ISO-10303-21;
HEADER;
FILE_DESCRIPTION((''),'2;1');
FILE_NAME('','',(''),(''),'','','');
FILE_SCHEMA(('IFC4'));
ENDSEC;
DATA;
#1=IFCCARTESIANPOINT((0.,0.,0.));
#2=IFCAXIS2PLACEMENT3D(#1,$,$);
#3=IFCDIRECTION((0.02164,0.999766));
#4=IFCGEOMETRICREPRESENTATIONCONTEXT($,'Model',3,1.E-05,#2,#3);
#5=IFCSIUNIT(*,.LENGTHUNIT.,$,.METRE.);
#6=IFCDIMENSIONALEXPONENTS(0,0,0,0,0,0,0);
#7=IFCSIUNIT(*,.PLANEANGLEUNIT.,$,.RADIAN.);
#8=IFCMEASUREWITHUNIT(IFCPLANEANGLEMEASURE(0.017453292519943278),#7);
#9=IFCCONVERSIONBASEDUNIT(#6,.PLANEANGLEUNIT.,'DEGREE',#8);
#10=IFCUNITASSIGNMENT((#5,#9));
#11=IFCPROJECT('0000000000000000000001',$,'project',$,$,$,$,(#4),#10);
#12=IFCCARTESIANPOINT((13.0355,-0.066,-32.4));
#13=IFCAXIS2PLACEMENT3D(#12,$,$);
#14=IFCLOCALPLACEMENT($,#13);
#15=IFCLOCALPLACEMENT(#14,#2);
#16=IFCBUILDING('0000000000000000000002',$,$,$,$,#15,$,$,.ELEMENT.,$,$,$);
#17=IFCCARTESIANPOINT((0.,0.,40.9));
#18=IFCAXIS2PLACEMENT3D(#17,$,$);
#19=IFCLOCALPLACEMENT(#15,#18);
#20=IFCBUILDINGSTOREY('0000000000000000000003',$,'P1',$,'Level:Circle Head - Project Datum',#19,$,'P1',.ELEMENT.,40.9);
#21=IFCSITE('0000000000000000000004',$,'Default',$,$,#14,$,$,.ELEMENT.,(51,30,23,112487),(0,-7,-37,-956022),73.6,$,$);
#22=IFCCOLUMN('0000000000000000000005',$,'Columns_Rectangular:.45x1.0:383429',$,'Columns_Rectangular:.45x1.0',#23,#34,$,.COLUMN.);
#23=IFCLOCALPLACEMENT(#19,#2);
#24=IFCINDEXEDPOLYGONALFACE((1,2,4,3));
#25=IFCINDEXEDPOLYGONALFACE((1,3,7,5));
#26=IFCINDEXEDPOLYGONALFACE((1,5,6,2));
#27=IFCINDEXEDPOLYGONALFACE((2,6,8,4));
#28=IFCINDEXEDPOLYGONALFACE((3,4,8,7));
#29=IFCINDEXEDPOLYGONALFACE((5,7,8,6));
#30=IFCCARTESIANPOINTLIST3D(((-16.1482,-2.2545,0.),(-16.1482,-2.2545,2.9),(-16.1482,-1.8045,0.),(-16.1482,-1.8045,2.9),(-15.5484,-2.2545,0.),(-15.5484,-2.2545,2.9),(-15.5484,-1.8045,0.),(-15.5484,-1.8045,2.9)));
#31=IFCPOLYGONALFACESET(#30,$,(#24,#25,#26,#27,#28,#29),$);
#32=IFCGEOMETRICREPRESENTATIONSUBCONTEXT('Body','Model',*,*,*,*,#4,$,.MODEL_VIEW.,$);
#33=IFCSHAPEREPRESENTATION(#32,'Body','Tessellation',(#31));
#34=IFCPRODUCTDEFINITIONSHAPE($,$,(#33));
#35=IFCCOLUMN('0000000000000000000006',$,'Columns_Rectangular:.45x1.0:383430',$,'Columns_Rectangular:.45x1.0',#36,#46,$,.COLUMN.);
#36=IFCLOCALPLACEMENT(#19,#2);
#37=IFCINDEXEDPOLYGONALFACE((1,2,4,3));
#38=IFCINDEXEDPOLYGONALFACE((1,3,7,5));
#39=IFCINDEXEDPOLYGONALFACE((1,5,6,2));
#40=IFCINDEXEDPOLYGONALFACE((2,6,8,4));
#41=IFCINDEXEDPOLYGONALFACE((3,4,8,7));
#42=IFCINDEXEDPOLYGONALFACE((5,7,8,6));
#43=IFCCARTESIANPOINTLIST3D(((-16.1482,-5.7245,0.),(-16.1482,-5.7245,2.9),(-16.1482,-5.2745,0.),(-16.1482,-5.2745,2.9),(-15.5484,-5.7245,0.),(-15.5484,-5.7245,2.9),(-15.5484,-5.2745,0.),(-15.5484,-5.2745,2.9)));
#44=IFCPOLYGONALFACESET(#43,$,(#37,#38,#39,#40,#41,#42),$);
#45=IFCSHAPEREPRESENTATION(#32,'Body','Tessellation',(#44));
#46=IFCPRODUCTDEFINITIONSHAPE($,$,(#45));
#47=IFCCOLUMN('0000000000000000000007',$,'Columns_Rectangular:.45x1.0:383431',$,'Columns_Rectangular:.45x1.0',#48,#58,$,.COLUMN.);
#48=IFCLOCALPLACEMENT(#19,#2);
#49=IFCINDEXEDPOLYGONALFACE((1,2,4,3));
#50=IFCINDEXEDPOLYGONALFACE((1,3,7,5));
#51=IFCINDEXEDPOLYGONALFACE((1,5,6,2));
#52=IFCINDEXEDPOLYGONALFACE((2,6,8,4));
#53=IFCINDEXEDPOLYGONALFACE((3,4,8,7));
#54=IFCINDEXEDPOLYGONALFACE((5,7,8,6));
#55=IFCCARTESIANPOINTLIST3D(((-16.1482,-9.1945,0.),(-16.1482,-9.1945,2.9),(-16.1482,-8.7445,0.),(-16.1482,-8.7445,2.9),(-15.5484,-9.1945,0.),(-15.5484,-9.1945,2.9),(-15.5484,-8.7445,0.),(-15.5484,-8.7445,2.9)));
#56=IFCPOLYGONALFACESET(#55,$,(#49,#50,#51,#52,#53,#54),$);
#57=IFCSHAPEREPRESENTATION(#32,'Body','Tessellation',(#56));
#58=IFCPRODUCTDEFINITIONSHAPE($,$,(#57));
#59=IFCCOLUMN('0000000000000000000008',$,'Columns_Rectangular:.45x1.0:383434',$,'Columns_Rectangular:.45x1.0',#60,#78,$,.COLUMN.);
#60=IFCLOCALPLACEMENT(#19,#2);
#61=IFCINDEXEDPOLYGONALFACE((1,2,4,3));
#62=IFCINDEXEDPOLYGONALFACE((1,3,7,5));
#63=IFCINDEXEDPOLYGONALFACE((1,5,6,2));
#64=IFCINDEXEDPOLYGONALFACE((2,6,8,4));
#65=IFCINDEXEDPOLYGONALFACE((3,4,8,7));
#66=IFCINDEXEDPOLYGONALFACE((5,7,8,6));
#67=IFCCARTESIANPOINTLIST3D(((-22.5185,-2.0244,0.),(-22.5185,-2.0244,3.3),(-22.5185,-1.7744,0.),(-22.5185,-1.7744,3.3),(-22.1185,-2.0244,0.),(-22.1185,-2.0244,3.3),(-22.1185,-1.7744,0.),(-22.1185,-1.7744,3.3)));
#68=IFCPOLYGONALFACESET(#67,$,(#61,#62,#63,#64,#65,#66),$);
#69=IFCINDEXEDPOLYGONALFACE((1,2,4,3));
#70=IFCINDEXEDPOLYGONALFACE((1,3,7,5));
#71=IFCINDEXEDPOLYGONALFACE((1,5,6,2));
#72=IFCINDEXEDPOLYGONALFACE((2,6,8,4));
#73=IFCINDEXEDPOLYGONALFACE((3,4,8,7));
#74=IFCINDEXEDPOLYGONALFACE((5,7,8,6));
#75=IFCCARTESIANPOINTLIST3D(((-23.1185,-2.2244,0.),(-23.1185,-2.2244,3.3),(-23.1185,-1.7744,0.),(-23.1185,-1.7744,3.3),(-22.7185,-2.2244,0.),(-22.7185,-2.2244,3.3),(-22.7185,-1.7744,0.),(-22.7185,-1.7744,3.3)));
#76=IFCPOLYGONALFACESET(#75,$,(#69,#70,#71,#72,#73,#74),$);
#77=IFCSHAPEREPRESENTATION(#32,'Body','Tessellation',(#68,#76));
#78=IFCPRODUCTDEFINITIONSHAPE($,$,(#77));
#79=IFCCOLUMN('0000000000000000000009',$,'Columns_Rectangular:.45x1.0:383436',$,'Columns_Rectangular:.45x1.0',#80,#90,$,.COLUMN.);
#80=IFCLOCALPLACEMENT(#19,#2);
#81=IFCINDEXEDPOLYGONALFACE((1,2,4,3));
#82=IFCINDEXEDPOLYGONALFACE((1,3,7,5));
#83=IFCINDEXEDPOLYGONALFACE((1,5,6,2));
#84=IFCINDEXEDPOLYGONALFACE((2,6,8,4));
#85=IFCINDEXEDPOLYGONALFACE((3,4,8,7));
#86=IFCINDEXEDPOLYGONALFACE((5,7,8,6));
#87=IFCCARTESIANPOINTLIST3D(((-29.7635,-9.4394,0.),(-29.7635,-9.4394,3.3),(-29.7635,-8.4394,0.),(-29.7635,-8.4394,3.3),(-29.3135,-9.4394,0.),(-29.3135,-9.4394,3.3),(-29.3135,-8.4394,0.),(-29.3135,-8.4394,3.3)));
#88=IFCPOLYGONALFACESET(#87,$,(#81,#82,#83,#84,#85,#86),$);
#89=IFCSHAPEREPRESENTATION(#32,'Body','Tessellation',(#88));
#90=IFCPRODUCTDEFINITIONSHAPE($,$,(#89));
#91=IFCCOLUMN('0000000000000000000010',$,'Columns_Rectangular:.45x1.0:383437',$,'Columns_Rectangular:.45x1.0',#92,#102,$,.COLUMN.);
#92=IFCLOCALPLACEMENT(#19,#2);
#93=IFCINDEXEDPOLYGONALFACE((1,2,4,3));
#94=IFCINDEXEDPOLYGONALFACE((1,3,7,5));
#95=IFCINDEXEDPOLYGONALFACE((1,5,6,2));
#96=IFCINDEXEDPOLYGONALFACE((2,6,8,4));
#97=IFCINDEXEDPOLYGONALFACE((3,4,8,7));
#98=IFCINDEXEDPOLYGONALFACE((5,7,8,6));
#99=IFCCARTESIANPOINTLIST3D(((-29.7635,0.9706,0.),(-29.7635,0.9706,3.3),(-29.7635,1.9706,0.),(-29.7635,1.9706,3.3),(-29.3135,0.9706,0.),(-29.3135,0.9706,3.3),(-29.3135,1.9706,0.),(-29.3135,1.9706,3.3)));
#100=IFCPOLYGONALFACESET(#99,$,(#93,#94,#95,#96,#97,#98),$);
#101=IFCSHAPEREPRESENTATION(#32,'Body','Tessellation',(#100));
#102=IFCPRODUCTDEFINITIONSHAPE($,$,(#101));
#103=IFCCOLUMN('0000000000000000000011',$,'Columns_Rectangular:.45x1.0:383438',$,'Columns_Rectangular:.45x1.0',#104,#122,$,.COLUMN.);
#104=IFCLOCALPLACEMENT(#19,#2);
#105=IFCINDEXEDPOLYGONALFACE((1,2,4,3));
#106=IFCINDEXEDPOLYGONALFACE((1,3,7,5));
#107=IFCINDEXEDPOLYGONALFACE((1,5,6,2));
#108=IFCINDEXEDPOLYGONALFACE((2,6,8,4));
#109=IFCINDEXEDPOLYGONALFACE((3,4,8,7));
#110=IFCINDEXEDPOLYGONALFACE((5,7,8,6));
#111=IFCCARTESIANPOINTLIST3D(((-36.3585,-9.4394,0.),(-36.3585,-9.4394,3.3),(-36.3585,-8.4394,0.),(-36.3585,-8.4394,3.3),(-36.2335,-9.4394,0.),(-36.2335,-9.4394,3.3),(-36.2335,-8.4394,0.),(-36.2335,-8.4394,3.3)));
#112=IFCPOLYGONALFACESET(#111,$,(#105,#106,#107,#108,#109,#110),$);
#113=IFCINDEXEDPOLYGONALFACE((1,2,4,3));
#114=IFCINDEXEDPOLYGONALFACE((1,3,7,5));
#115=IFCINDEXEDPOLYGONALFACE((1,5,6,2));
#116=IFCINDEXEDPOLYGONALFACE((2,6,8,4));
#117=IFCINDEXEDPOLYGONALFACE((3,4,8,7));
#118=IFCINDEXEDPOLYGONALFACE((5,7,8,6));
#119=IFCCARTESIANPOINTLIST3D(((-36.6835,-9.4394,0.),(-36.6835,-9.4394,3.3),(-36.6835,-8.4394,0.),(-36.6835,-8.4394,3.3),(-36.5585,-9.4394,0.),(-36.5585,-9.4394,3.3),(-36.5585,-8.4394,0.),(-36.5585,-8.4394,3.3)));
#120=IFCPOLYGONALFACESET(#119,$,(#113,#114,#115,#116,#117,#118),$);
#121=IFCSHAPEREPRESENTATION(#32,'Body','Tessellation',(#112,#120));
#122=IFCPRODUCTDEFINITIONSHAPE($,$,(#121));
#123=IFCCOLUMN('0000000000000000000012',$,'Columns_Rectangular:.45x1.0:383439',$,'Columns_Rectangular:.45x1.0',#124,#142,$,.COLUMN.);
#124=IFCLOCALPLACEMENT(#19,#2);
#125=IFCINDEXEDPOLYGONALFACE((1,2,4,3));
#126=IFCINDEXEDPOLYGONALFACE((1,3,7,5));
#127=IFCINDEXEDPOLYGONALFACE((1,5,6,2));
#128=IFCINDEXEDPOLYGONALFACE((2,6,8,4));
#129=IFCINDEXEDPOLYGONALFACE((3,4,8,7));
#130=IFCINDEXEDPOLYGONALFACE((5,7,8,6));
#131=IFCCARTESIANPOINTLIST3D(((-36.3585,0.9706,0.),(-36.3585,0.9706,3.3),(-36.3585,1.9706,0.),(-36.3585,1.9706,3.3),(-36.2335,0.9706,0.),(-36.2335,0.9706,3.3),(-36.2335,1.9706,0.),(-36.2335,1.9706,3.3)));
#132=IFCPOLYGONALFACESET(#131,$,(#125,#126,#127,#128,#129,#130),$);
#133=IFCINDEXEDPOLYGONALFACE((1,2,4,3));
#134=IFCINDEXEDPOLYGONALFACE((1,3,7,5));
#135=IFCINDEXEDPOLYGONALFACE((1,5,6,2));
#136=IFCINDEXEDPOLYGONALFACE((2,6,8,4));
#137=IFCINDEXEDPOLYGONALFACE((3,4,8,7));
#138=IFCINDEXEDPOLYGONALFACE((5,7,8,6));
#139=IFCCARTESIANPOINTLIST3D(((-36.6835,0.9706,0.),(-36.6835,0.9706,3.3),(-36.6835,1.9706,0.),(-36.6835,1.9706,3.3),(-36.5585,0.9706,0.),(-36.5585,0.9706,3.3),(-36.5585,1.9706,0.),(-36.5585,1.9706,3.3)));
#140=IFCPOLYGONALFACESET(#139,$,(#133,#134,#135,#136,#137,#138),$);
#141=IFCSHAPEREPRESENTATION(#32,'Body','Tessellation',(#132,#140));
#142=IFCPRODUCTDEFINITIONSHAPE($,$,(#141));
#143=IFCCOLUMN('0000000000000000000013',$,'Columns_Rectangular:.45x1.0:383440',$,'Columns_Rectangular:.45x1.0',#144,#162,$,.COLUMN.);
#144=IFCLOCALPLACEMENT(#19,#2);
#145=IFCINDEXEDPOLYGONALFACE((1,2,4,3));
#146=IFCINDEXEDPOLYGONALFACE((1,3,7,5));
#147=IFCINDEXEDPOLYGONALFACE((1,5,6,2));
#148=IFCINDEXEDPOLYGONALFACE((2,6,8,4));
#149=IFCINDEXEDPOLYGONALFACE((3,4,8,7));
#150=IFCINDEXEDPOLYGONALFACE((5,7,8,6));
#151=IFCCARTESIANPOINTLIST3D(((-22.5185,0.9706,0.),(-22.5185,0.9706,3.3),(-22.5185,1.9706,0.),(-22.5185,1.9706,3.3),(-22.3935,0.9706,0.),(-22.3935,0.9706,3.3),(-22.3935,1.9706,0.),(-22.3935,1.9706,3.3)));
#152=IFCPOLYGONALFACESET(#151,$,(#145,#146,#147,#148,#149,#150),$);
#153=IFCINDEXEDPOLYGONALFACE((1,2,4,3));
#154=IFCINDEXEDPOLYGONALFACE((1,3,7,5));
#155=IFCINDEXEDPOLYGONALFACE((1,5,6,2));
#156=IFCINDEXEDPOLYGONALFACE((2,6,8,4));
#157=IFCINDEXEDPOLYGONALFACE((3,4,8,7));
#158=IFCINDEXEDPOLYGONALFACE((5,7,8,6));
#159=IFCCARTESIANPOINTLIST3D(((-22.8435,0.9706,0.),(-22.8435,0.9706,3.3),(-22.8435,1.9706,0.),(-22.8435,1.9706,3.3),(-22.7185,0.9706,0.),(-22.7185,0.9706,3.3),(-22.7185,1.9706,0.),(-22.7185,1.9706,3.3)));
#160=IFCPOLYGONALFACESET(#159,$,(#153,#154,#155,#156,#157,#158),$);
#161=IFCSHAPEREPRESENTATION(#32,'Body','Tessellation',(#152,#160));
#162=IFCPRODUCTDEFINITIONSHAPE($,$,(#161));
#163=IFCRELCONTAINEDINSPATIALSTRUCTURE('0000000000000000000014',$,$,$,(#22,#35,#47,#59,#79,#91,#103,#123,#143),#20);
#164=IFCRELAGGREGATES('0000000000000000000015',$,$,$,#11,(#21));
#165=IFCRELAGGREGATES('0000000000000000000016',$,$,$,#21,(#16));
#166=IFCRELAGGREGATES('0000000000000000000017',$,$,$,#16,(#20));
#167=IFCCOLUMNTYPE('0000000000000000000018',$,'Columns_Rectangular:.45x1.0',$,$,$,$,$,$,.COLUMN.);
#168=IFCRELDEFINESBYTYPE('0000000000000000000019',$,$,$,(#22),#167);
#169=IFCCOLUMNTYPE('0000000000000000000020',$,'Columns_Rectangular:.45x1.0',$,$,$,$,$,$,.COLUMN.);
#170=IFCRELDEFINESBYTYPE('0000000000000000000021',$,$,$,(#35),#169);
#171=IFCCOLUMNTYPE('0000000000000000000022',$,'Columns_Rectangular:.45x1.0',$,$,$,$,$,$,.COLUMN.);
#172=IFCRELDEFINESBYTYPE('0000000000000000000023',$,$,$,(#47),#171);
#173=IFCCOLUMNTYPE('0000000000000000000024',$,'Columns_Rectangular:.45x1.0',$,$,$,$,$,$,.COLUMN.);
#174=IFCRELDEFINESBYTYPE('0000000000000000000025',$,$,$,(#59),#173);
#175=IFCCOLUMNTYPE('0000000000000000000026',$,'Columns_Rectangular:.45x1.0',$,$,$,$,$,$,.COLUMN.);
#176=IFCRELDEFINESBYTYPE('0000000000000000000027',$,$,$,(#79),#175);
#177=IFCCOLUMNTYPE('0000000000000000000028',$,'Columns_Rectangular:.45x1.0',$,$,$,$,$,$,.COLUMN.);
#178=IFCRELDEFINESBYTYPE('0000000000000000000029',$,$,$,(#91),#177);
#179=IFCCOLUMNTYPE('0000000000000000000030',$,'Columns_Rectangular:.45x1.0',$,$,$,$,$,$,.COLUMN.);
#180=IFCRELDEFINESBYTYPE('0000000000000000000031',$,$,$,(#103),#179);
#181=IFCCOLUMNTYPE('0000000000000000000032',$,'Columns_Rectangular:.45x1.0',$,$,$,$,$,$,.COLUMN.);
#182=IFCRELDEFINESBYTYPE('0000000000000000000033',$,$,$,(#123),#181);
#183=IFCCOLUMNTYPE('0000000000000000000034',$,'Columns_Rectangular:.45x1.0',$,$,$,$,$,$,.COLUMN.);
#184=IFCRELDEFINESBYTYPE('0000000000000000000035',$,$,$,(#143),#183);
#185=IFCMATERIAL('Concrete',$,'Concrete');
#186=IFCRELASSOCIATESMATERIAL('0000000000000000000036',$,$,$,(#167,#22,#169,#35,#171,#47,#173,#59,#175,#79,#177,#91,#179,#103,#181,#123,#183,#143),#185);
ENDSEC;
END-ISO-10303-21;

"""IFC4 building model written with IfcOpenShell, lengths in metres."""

from ifc_helpers import new_model, entity, si_unit, converted_unit, direction, frame, origin, place, context, subcontext, project, spatial, indexed_curve, outline, extrude, source, transform, mapped, material, type_object, type_shapes, element, save


model = new_model("IFC4")

# Units and contexts
model_context = context("Model", 3, precision=1e-05, world=origin(), true_north=direction((0.02164, 0.999766)))
body_context = subcontext(model_context, "Body", "Model", "MODEL_VIEW")
ifc_project = project(units=[si_unit("LENGTHUNIT", "METRE"), converted_unit("PLANEANGLEUNIT", "DEGREE", entity("IfcPlaneAngleMeasure", 0.017453292519943278), si_unit("PLANEANGLEUNIT", "RADIAN"), dimensions=[0, 0, 0, 0, 0, 0, 0])], contexts=[model_context])

# Site, building, storey
site_placement = place(None, frame((13.0355, -0.066, -32.4)))
site = spatial("IfcSite", under=ifc_project, at=site_placement, Name="Default", CompositionType="ELEMENT", RefLatitude=(51, 30, 23, 112487), RefLongitude=(0, -7, -37, -956022), RefElevation=73.6)
building_placement = place(site_placement, origin())
building = spatial("IfcBuilding", under=site, at=building_placement, CompositionType="ELEMENT")
storey_placement = place(building_placement, frame((0.0, 0.0, 40.9)))
storey = spatial("IfcBuildingStorey", under=building, at=storey_placement, Name="P1", ObjectType="Level:Circle Head - Project Datum", LongName="P1", CompositionType="ELEMENT", Elevation=40.9)

# Columns
ifc_material = material(Name="Concrete", Category="Concrete")
column_type_1 = type_object("IfcColumnType", Name="Columns_Rectangular:.45x1.0", PredefinedType="COLUMN", material=ifc_material)
shared_shape_1 = source(origin(), body_context, "Body", "SweptSolid", [
    extrude(outline(indexed_curve([(-0.2999, -0.225), (0.2999, -0.225), (0.2999, 0.225), (-0.2999, 0.225), (-0.2999, -0.225)], self_intersect=False)), frame((-15.8483, -2.0295, 40.9), z_axis=(0.0, 0.0, 1.0), x_axis=(-1.0, 0.0, 0.0)), (0.0, 0.0, 1.0), 2.9),
])
type_shapes(column_type_1, [shared_shape_1])
column_1_placement = place(storey_placement, frame((0.0, 0.0, -40.9)))
element("IfcColumn", 1, at=column_1_placement, inside=storey, type_object=column_type_1, material=ifc_material, Name="Columns_Rectangular:.45x1.0:383429", ObjectType="Columns_Rectangular:.45x1.0", PredefinedType="COLUMN", context=body_context, shape_type="MappedRepresentation", body=[
    mapped(shared_shape_1, transform((0.0, 0.0, 0.0), scale=1.0)),
])
column_type_2 = type_object("IfcColumnType", Name="Columns_Rectangular:.45x1.0", PredefinedType="COLUMN", material=ifc_material)
shared_shape_2 = source(origin(), body_context, "Body", "SweptSolid", [
    extrude(outline(indexed_curve([(-0.2999, -0.225), (0.2999, -0.225), (0.2999, 0.225), (-0.2999, 0.225), (-0.2999, -0.225)], self_intersect=False)), frame((-15.8483, -5.4995, 40.9), z_axis=(0.0, 0.0, 1.0), x_axis=(-1.0, 0.0, 0.0)), (0.0, 0.0, 1.0), 2.9),
])
type_shapes(column_type_2, [shared_shape_2])
column_2_placement = place(storey_placement, frame((0.0, 0.0, -40.9)))
element("IfcColumn", 2, at=column_2_placement, inside=storey, type_object=column_type_2, material=ifc_material, Name="Columns_Rectangular:.45x1.0:383430", ObjectType="Columns_Rectangular:.45x1.0", PredefinedType="COLUMN", context=body_context, shape_type="MappedRepresentation", body=[
    mapped(shared_shape_2, transform((0.0, 0.0, 0.0), scale=1.0)),
])
column_type_3 = type_object("IfcColumnType", Name="Columns_Rectangular:.45x1.0", PredefinedType="COLUMN", material=ifc_material)
shared_shape_3 = source(origin(), body_context, "Body", "SweptSolid", [
    extrude(outline(indexed_curve([(-0.2999, -0.225), (0.2999, -0.225), (0.2999, 0.225), (-0.2999, 0.225), (-0.2999, -0.225)], self_intersect=False)), frame((-15.8483, -8.9695, 40.9), z_axis=(0.0, 0.0, 1.0), x_axis=(-1.0, 0.0, 0.0)), (0.0, 0.0, 1.0), 2.9),
])
type_shapes(column_type_3, [shared_shape_3])
column_3_placement = place(storey_placement, frame((0.0, 0.0, -40.9)))
element("IfcColumn", 3, at=column_3_placement, inside=storey, type_object=column_type_3, material=ifc_material, Name="Columns_Rectangular:.45x1.0:383431", ObjectType="Columns_Rectangular:.45x1.0", PredefinedType="COLUMN", context=body_context, shape_type="MappedRepresentation", body=[
    mapped(shared_shape_3, transform((0.0, 0.0, 0.0), scale=1.0)),
])
column_type_4 = type_object("IfcColumnType", Name="Columns_Rectangular:.45x1.0", PredefinedType="COLUMN", material=ifc_material)
shared_shape_4 = source(origin(), body_context, "Body", "SweptSolid", [
    extrude(outline(indexed_curve([(-0.125, -0.2), (0.125, -0.2), (0.125, 0.2), (-0.125, 0.2), (-0.125, -0.2)], self_intersect=False)), frame((-22.3185, -1.8994, 40.9), z_axis=(0.0, 0.0, 1.0), x_axis=(0.0, -1.0, 0.0)), (0.0, 0.0, 1.0), 3.3),
    extrude(outline(indexed_curve([(-0.2, -0.225), (0.2, -0.225), (0.2, 0.225), (-0.2, 0.225), (-0.2, -0.225)], self_intersect=False)), frame((-22.9185, -1.9994, 40.9)), (0.0, 0.0, 1.0), 3.3),
])
type_shapes(column_type_4, [shared_shape_4])
column_4_placement = place(storey_placement, frame((0.0, 0.0, -40.9)))
element("IfcColumn", 4, at=column_4_placement, inside=storey, type_object=column_type_4, material=ifc_material, Name="Columns_Rectangular:.45x1.0:383434", ObjectType="Columns_Rectangular:.45x1.0", PredefinedType="COLUMN", context=body_context, shape_type="MappedRepresentation", body=[
    mapped(shared_shape_4, transform((0.0, 0.0, 0.0), scale=1.0)),
])
column_type_5 = type_object("IfcColumnType", Name="Columns_Rectangular:.45x1.0", PredefinedType="COLUMN", material=ifc_material)
shared_shape_5 = source(origin(), body_context, "Body", "SweptSolid", [
    extrude(outline(indexed_curve([(-0.5, -0.225), (0.5, -0.225), (0.5, 0.225), (-0.5, 0.225), (-0.5, -0.225)], self_intersect=False)), frame((-29.5385, -8.9394, 40.9), z_axis=(0.0, 0.0, 1.0), x_axis=(0.0, 1.0, 0.0)), (0.0, 0.0, 1.0), 3.3),
])
type_shapes(column_type_5, [shared_shape_5])
column_5_placement = place(storey_placement, frame((0.0, 0.0, -40.9)))
element("IfcColumn", 5, at=column_5_placement, inside=storey, type_object=column_type_5, material=ifc_material, Name="Columns_Rectangular:.45x1.0:383436", ObjectType="Columns_Rectangular:.45x1.0", PredefinedType="COLUMN", context=body_context, shape_type="MappedRepresentation", body=[
    mapped(shared_shape_5, transform((0.0, 0.0, 0.0), scale=1.0)),
])
column_type_6 = type_object("IfcColumnType", Name="Columns_Rectangular:.45x1.0", PredefinedType="COLUMN", material=ifc_material)
shared_shape_6 = source(origin(), body_context, "Body", "SweptSolid", [
    extrude(outline(indexed_curve([(-0.5, -0.225), (0.5, -0.225), (0.5, 0.225), (-0.5, 0.225), (-0.5, -0.225)], self_intersect=False)), frame((-29.5385, 1.4706, 40.9), z_axis=(0.0, 0.0, 1.0), x_axis=(0.0, 1.0, 0.0)), (0.0, 0.0, 1.0), 3.3),
])
type_shapes(column_type_6, [shared_shape_6])
column_6_placement = place(storey_placement, frame((0.0, 0.0, -40.9)))
element("IfcColumn", 6, at=column_6_placement, inside=storey, type_object=column_type_6, material=ifc_material, Name="Columns_Rectangular:.45x1.0:383437", ObjectType="Columns_Rectangular:.45x1.0", PredefinedType="COLUMN", context=body_context, shape_type="MappedRepresentation", body=[
    mapped(shared_shape_6, transform((0.0, 0.0, 0.0), scale=1.0)),
])
column_type_7 = type_object("IfcColumnType", Name="Columns_Rectangular:.45x1.0", PredefinedType="COLUMN", material=ifc_material)
shared_shape_7 = source(origin(), body_context, "Body", "SweptSolid", [
    extrude(outline(indexed_curve([(-0.0625, -0.5), (0.0625, -0.5), (0.0625, 0.5), (-0.0625, 0.5), (-0.0625, -0.5)], self_intersect=False)), frame((-36.296, -8.9394, 40.9), z_axis=(0.0, 0.0, 1.0), x_axis=(-1.0, 0.0, 0.0)), (0.0, 0.0, 1.0), 3.3),
    extrude(outline(indexed_curve([(-0.0625, -0.5), (0.0625, -0.5), (0.0625, 0.5), (-0.0625, 0.5), (-0.0625, -0.5)], self_intersect=False)), frame((-36.621, -8.9394, 40.9)), (0.0, 0.0, 1.0), 3.3),
])
type_shapes(column_type_7, [shared_shape_7])
column_7_placement = place(storey_placement, frame((0.0, 0.0, -40.9)))
element("IfcColumn", 7, at=column_7_placement, inside=storey, type_object=column_type_7, material=ifc_material, Name="Columns_Rectangular:.45x1.0:383438", ObjectType="Columns_Rectangular:.45x1.0", PredefinedType="COLUMN", context=body_context, shape_type="MappedRepresentation", body=[
    mapped(shared_shape_7, transform((0.0, 0.0, 0.0), scale=1.0)),
])
column_type_8 = type_object("IfcColumnType", Name="Columns_Rectangular:.45x1.0", PredefinedType="COLUMN", material=ifc_material)
shared_shape_8 = source(origin(), body_context, "Body", "SweptSolid", [
    extrude(outline(indexed_curve([(-0.0625, -0.5), (0.0625, -0.5), (0.0625, 0.5), (-0.0625, 0.5), (-0.0625, -0.5)], self_intersect=False)), frame((-36.296, 1.4706, 40.9), z_axis=(0.0, 0.0, 1.0), x_axis=(-1.0, 0.0, 0.0)), (0.0, 0.0, 1.0), 3.3),
    extrude(outline(indexed_curve([(-0.0625, -0.5), (0.0625, -0.5), (0.0625, 0.5), (-0.0625, 0.5), (-0.0625, -0.5)], self_intersect=False)), frame((-36.621, 1.4706, 40.9)), (0.0, 0.0, 1.0), 3.3),
])
type_shapes(column_type_8, [shared_shape_8])
column_8_placement = place(storey_placement, frame((0.0, 0.0, -40.9)))
element("IfcColumn", 8, at=column_8_placement, inside=storey, type_object=column_type_8, material=ifc_material, Name="Columns_Rectangular:.45x1.0:383439", ObjectType="Columns_Rectangular:.45x1.0", PredefinedType="COLUMN", context=body_context, shape_type="MappedRepresentation", body=[
    mapped(shared_shape_8, transform((0.0, 0.0, 0.0), scale=1.0)),
])
column_type_9 = type_object("IfcColumnType", Name="Columns_Rectangular:.45x1.0", PredefinedType="COLUMN", material=ifc_material)
shared_shape_9 = source(origin(), body_context, "Body", "SweptSolid", [
    extrude(outline(indexed_curve([(-0.0625, -0.5), (0.0625, -0.5), (0.0625, 0.5), (-0.0625, 0.5), (-0.0625, -0.5)], self_intersect=False)), frame((-22.456, 1.4706, 40.9), z_axis=(0.0, 0.0, 1.0), x_axis=(-1.0, 0.0, 0.0)), (0.0, 0.0, 1.0), 3.3),
    extrude(outline(indexed_curve([(-0.0625, -0.5), (0.0625, -0.5), (0.0625, 0.5), (-0.0625, 0.5), (-0.0625, -0.5)], self_intersect=False)), frame((-22.781, 1.4706, 40.9)), (0.0, 0.0, 1.0), 3.3),
])
type_shapes(column_type_9, [shared_shape_9])
column_9_placement = place(storey_placement, frame((0.0, 0.0, -40.9)))
element("IfcColumn", 9, at=column_9_placement, inside=storey, type_object=column_type_9, material=ifc_material, Name="Columns_Rectangular:.45x1.0:383440", ObjectType="Columns_Rectangular:.45x1.0", PredefinedType="COLUMN", context=body_context, shape_type="MappedRepresentation", body=[
    mapped(shared_shape_9, transform((0.0, 0.0, 0.0), scale=1.0)),
])

save(model, "model.ifc")
